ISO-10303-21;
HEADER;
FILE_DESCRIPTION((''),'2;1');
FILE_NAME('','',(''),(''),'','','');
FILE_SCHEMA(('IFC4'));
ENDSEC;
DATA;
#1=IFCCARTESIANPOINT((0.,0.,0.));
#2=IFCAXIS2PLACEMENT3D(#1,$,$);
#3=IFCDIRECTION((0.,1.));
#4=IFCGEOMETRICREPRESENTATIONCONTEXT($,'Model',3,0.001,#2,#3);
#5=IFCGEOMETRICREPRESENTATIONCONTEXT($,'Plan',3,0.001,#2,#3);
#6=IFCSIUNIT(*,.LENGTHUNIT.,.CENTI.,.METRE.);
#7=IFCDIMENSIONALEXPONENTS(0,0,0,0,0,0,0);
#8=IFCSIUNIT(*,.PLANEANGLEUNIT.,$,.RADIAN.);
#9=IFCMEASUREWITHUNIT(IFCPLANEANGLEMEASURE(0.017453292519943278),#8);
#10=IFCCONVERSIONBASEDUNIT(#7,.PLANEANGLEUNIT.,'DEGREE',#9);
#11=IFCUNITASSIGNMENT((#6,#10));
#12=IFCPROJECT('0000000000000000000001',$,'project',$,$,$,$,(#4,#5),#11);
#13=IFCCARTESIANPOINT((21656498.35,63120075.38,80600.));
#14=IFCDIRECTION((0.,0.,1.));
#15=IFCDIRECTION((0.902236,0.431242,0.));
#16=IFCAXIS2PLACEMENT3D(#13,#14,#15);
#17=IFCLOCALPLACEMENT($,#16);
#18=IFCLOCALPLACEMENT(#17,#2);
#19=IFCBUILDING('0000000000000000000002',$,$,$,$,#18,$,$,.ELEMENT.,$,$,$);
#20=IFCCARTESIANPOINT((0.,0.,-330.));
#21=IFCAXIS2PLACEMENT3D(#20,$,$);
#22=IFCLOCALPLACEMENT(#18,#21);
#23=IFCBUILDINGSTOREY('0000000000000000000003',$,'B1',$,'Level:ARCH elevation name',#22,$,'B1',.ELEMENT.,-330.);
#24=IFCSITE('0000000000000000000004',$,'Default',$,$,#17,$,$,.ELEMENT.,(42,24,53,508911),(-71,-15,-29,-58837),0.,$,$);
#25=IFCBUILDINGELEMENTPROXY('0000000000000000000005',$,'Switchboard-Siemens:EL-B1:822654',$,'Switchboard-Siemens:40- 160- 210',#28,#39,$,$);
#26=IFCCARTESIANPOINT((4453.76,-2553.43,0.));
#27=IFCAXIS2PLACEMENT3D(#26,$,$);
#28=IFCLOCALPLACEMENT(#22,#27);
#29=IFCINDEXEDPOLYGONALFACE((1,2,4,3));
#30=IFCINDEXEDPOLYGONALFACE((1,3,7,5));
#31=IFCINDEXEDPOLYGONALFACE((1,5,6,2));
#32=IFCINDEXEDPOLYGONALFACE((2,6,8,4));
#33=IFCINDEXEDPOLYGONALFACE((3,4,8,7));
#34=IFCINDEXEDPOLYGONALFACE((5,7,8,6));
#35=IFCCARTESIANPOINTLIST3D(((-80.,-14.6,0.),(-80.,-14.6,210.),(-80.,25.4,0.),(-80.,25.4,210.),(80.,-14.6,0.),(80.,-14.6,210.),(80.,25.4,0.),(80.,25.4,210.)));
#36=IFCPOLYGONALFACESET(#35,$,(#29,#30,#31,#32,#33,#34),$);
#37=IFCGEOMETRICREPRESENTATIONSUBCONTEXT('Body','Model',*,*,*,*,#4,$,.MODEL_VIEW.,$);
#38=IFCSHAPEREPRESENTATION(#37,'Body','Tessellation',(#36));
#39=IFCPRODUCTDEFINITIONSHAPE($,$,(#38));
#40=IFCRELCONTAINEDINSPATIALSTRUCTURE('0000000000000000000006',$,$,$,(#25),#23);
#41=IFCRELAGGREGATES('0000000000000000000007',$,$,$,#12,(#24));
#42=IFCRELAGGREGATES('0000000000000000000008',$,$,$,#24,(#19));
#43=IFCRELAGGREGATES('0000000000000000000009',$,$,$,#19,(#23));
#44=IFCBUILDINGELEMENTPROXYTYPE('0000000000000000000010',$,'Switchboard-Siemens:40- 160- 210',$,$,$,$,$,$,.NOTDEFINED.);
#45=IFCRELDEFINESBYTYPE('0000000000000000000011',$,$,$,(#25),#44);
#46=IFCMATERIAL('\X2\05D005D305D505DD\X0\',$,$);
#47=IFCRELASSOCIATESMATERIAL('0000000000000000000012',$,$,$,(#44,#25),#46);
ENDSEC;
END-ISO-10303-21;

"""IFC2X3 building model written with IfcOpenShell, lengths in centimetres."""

from ifc_helpers import new_model, entity, si_unit, converted_unit, direction, frame, origin, origin_2d_with_axis, place, context, subcontext, project, spatial, rectangle, extrude, source, transform, mapped, material, type_object, type_shapes, element, save


model = new_model("IFC2X3")

# Units and contexts
model_context = context("Model", 3, precision=0.001, world=origin(), true_north=direction((0.0, 1.0)))
plan_context = context("Plan", 3, precision=0.001, world=origin(), true_north=direction((0.0, 1.0)))
body_context = subcontext(model_context, "Body", "Model", "MODEL_VIEW")
ifc_project = project(units=[si_unit("LENGTHUNIT", "METRE", prefix="CENTI"), converted_unit("PLANEANGLEUNIT", "DEGREE", entity("IfcPlaneAngleMeasure", 0.017453292519943278), si_unit("PLANEANGLEUNIT", "RADIAN"), dimensions=[0, 0, 0, 0, 0, 0, 0])], contexts=[model_context, plan_context])

# Site, building, storey
site_placement = place(None, frame((21656498.35, 63120075.38, 80600.0), z_axis=(0.0, 0.0, 1.0), x_axis=(0.902236, 0.431242, 0.0)))
site = spatial("IfcSite", under=ifc_project, at=site_placement, Name="Default", CompositionType="ELEMENT", RefLatitude=(42, 24, 53, 508911), RefLongitude=(-71, -15, -29, -58837), RefElevation=0.0)
building_placement = place(site_placement, origin())
building = spatial("IfcBuilding", under=site, at=building_placement, CompositionType="ELEMENT")
storey_placement = place(building_placement, frame((0.0, 0.0, -330.0)))
storey = spatial("IfcBuildingStorey", under=building, at=storey_placement, Name="B1", ObjectType="Level:ARCH elevation name", LongName="B1", CompositionType="ELEMENT", Elevation=-330.0)

# Building element proxy
ifc_material_1 = material(Name="אדום")
building_element_proxy_type_1 = type_object("IfcBuildingElementProxyType", Name="Switchboard-Siemens:40- 160- 210", PredefinedType="NOTDEFINED", material=ifc_material_1)
shared_shape_1 = source(origin(), body_context, "Body", "SweptSolid", [
    extrude(rectangle(XDim=160.0, YDim=40.0, at=origin_2d_with_axis()), frame((0.0, 5.4, 0.0), z_axis=(0.0, 0.0, 1.0), x_axis=(-1.0, 0.0, 0.0)), (0.0, 0.0, 1.0), 210.0),
])
type_shapes(building_element_proxy_type_1, [shared_shape_1])
proxy_1_placement = place(storey_placement, frame((4453.76, -2553.43, 0.0)))
element("IfcBuildingElementProxy", 1, at=proxy_1_placement, inside=storey, type_object=building_element_proxy_type_1, material=ifc_material_1, Name="Switchboard-Siemens:EL-B1:822654", ObjectType="Switchboard-Siemens:40- 160- 210", context=body_context, shape_type="MappedRepresentation", body=[
    mapped(shared_shape_1, transform((0.0, 0.0, 0.0), scale=1.0)),
])

save(model, "model.ifc")
